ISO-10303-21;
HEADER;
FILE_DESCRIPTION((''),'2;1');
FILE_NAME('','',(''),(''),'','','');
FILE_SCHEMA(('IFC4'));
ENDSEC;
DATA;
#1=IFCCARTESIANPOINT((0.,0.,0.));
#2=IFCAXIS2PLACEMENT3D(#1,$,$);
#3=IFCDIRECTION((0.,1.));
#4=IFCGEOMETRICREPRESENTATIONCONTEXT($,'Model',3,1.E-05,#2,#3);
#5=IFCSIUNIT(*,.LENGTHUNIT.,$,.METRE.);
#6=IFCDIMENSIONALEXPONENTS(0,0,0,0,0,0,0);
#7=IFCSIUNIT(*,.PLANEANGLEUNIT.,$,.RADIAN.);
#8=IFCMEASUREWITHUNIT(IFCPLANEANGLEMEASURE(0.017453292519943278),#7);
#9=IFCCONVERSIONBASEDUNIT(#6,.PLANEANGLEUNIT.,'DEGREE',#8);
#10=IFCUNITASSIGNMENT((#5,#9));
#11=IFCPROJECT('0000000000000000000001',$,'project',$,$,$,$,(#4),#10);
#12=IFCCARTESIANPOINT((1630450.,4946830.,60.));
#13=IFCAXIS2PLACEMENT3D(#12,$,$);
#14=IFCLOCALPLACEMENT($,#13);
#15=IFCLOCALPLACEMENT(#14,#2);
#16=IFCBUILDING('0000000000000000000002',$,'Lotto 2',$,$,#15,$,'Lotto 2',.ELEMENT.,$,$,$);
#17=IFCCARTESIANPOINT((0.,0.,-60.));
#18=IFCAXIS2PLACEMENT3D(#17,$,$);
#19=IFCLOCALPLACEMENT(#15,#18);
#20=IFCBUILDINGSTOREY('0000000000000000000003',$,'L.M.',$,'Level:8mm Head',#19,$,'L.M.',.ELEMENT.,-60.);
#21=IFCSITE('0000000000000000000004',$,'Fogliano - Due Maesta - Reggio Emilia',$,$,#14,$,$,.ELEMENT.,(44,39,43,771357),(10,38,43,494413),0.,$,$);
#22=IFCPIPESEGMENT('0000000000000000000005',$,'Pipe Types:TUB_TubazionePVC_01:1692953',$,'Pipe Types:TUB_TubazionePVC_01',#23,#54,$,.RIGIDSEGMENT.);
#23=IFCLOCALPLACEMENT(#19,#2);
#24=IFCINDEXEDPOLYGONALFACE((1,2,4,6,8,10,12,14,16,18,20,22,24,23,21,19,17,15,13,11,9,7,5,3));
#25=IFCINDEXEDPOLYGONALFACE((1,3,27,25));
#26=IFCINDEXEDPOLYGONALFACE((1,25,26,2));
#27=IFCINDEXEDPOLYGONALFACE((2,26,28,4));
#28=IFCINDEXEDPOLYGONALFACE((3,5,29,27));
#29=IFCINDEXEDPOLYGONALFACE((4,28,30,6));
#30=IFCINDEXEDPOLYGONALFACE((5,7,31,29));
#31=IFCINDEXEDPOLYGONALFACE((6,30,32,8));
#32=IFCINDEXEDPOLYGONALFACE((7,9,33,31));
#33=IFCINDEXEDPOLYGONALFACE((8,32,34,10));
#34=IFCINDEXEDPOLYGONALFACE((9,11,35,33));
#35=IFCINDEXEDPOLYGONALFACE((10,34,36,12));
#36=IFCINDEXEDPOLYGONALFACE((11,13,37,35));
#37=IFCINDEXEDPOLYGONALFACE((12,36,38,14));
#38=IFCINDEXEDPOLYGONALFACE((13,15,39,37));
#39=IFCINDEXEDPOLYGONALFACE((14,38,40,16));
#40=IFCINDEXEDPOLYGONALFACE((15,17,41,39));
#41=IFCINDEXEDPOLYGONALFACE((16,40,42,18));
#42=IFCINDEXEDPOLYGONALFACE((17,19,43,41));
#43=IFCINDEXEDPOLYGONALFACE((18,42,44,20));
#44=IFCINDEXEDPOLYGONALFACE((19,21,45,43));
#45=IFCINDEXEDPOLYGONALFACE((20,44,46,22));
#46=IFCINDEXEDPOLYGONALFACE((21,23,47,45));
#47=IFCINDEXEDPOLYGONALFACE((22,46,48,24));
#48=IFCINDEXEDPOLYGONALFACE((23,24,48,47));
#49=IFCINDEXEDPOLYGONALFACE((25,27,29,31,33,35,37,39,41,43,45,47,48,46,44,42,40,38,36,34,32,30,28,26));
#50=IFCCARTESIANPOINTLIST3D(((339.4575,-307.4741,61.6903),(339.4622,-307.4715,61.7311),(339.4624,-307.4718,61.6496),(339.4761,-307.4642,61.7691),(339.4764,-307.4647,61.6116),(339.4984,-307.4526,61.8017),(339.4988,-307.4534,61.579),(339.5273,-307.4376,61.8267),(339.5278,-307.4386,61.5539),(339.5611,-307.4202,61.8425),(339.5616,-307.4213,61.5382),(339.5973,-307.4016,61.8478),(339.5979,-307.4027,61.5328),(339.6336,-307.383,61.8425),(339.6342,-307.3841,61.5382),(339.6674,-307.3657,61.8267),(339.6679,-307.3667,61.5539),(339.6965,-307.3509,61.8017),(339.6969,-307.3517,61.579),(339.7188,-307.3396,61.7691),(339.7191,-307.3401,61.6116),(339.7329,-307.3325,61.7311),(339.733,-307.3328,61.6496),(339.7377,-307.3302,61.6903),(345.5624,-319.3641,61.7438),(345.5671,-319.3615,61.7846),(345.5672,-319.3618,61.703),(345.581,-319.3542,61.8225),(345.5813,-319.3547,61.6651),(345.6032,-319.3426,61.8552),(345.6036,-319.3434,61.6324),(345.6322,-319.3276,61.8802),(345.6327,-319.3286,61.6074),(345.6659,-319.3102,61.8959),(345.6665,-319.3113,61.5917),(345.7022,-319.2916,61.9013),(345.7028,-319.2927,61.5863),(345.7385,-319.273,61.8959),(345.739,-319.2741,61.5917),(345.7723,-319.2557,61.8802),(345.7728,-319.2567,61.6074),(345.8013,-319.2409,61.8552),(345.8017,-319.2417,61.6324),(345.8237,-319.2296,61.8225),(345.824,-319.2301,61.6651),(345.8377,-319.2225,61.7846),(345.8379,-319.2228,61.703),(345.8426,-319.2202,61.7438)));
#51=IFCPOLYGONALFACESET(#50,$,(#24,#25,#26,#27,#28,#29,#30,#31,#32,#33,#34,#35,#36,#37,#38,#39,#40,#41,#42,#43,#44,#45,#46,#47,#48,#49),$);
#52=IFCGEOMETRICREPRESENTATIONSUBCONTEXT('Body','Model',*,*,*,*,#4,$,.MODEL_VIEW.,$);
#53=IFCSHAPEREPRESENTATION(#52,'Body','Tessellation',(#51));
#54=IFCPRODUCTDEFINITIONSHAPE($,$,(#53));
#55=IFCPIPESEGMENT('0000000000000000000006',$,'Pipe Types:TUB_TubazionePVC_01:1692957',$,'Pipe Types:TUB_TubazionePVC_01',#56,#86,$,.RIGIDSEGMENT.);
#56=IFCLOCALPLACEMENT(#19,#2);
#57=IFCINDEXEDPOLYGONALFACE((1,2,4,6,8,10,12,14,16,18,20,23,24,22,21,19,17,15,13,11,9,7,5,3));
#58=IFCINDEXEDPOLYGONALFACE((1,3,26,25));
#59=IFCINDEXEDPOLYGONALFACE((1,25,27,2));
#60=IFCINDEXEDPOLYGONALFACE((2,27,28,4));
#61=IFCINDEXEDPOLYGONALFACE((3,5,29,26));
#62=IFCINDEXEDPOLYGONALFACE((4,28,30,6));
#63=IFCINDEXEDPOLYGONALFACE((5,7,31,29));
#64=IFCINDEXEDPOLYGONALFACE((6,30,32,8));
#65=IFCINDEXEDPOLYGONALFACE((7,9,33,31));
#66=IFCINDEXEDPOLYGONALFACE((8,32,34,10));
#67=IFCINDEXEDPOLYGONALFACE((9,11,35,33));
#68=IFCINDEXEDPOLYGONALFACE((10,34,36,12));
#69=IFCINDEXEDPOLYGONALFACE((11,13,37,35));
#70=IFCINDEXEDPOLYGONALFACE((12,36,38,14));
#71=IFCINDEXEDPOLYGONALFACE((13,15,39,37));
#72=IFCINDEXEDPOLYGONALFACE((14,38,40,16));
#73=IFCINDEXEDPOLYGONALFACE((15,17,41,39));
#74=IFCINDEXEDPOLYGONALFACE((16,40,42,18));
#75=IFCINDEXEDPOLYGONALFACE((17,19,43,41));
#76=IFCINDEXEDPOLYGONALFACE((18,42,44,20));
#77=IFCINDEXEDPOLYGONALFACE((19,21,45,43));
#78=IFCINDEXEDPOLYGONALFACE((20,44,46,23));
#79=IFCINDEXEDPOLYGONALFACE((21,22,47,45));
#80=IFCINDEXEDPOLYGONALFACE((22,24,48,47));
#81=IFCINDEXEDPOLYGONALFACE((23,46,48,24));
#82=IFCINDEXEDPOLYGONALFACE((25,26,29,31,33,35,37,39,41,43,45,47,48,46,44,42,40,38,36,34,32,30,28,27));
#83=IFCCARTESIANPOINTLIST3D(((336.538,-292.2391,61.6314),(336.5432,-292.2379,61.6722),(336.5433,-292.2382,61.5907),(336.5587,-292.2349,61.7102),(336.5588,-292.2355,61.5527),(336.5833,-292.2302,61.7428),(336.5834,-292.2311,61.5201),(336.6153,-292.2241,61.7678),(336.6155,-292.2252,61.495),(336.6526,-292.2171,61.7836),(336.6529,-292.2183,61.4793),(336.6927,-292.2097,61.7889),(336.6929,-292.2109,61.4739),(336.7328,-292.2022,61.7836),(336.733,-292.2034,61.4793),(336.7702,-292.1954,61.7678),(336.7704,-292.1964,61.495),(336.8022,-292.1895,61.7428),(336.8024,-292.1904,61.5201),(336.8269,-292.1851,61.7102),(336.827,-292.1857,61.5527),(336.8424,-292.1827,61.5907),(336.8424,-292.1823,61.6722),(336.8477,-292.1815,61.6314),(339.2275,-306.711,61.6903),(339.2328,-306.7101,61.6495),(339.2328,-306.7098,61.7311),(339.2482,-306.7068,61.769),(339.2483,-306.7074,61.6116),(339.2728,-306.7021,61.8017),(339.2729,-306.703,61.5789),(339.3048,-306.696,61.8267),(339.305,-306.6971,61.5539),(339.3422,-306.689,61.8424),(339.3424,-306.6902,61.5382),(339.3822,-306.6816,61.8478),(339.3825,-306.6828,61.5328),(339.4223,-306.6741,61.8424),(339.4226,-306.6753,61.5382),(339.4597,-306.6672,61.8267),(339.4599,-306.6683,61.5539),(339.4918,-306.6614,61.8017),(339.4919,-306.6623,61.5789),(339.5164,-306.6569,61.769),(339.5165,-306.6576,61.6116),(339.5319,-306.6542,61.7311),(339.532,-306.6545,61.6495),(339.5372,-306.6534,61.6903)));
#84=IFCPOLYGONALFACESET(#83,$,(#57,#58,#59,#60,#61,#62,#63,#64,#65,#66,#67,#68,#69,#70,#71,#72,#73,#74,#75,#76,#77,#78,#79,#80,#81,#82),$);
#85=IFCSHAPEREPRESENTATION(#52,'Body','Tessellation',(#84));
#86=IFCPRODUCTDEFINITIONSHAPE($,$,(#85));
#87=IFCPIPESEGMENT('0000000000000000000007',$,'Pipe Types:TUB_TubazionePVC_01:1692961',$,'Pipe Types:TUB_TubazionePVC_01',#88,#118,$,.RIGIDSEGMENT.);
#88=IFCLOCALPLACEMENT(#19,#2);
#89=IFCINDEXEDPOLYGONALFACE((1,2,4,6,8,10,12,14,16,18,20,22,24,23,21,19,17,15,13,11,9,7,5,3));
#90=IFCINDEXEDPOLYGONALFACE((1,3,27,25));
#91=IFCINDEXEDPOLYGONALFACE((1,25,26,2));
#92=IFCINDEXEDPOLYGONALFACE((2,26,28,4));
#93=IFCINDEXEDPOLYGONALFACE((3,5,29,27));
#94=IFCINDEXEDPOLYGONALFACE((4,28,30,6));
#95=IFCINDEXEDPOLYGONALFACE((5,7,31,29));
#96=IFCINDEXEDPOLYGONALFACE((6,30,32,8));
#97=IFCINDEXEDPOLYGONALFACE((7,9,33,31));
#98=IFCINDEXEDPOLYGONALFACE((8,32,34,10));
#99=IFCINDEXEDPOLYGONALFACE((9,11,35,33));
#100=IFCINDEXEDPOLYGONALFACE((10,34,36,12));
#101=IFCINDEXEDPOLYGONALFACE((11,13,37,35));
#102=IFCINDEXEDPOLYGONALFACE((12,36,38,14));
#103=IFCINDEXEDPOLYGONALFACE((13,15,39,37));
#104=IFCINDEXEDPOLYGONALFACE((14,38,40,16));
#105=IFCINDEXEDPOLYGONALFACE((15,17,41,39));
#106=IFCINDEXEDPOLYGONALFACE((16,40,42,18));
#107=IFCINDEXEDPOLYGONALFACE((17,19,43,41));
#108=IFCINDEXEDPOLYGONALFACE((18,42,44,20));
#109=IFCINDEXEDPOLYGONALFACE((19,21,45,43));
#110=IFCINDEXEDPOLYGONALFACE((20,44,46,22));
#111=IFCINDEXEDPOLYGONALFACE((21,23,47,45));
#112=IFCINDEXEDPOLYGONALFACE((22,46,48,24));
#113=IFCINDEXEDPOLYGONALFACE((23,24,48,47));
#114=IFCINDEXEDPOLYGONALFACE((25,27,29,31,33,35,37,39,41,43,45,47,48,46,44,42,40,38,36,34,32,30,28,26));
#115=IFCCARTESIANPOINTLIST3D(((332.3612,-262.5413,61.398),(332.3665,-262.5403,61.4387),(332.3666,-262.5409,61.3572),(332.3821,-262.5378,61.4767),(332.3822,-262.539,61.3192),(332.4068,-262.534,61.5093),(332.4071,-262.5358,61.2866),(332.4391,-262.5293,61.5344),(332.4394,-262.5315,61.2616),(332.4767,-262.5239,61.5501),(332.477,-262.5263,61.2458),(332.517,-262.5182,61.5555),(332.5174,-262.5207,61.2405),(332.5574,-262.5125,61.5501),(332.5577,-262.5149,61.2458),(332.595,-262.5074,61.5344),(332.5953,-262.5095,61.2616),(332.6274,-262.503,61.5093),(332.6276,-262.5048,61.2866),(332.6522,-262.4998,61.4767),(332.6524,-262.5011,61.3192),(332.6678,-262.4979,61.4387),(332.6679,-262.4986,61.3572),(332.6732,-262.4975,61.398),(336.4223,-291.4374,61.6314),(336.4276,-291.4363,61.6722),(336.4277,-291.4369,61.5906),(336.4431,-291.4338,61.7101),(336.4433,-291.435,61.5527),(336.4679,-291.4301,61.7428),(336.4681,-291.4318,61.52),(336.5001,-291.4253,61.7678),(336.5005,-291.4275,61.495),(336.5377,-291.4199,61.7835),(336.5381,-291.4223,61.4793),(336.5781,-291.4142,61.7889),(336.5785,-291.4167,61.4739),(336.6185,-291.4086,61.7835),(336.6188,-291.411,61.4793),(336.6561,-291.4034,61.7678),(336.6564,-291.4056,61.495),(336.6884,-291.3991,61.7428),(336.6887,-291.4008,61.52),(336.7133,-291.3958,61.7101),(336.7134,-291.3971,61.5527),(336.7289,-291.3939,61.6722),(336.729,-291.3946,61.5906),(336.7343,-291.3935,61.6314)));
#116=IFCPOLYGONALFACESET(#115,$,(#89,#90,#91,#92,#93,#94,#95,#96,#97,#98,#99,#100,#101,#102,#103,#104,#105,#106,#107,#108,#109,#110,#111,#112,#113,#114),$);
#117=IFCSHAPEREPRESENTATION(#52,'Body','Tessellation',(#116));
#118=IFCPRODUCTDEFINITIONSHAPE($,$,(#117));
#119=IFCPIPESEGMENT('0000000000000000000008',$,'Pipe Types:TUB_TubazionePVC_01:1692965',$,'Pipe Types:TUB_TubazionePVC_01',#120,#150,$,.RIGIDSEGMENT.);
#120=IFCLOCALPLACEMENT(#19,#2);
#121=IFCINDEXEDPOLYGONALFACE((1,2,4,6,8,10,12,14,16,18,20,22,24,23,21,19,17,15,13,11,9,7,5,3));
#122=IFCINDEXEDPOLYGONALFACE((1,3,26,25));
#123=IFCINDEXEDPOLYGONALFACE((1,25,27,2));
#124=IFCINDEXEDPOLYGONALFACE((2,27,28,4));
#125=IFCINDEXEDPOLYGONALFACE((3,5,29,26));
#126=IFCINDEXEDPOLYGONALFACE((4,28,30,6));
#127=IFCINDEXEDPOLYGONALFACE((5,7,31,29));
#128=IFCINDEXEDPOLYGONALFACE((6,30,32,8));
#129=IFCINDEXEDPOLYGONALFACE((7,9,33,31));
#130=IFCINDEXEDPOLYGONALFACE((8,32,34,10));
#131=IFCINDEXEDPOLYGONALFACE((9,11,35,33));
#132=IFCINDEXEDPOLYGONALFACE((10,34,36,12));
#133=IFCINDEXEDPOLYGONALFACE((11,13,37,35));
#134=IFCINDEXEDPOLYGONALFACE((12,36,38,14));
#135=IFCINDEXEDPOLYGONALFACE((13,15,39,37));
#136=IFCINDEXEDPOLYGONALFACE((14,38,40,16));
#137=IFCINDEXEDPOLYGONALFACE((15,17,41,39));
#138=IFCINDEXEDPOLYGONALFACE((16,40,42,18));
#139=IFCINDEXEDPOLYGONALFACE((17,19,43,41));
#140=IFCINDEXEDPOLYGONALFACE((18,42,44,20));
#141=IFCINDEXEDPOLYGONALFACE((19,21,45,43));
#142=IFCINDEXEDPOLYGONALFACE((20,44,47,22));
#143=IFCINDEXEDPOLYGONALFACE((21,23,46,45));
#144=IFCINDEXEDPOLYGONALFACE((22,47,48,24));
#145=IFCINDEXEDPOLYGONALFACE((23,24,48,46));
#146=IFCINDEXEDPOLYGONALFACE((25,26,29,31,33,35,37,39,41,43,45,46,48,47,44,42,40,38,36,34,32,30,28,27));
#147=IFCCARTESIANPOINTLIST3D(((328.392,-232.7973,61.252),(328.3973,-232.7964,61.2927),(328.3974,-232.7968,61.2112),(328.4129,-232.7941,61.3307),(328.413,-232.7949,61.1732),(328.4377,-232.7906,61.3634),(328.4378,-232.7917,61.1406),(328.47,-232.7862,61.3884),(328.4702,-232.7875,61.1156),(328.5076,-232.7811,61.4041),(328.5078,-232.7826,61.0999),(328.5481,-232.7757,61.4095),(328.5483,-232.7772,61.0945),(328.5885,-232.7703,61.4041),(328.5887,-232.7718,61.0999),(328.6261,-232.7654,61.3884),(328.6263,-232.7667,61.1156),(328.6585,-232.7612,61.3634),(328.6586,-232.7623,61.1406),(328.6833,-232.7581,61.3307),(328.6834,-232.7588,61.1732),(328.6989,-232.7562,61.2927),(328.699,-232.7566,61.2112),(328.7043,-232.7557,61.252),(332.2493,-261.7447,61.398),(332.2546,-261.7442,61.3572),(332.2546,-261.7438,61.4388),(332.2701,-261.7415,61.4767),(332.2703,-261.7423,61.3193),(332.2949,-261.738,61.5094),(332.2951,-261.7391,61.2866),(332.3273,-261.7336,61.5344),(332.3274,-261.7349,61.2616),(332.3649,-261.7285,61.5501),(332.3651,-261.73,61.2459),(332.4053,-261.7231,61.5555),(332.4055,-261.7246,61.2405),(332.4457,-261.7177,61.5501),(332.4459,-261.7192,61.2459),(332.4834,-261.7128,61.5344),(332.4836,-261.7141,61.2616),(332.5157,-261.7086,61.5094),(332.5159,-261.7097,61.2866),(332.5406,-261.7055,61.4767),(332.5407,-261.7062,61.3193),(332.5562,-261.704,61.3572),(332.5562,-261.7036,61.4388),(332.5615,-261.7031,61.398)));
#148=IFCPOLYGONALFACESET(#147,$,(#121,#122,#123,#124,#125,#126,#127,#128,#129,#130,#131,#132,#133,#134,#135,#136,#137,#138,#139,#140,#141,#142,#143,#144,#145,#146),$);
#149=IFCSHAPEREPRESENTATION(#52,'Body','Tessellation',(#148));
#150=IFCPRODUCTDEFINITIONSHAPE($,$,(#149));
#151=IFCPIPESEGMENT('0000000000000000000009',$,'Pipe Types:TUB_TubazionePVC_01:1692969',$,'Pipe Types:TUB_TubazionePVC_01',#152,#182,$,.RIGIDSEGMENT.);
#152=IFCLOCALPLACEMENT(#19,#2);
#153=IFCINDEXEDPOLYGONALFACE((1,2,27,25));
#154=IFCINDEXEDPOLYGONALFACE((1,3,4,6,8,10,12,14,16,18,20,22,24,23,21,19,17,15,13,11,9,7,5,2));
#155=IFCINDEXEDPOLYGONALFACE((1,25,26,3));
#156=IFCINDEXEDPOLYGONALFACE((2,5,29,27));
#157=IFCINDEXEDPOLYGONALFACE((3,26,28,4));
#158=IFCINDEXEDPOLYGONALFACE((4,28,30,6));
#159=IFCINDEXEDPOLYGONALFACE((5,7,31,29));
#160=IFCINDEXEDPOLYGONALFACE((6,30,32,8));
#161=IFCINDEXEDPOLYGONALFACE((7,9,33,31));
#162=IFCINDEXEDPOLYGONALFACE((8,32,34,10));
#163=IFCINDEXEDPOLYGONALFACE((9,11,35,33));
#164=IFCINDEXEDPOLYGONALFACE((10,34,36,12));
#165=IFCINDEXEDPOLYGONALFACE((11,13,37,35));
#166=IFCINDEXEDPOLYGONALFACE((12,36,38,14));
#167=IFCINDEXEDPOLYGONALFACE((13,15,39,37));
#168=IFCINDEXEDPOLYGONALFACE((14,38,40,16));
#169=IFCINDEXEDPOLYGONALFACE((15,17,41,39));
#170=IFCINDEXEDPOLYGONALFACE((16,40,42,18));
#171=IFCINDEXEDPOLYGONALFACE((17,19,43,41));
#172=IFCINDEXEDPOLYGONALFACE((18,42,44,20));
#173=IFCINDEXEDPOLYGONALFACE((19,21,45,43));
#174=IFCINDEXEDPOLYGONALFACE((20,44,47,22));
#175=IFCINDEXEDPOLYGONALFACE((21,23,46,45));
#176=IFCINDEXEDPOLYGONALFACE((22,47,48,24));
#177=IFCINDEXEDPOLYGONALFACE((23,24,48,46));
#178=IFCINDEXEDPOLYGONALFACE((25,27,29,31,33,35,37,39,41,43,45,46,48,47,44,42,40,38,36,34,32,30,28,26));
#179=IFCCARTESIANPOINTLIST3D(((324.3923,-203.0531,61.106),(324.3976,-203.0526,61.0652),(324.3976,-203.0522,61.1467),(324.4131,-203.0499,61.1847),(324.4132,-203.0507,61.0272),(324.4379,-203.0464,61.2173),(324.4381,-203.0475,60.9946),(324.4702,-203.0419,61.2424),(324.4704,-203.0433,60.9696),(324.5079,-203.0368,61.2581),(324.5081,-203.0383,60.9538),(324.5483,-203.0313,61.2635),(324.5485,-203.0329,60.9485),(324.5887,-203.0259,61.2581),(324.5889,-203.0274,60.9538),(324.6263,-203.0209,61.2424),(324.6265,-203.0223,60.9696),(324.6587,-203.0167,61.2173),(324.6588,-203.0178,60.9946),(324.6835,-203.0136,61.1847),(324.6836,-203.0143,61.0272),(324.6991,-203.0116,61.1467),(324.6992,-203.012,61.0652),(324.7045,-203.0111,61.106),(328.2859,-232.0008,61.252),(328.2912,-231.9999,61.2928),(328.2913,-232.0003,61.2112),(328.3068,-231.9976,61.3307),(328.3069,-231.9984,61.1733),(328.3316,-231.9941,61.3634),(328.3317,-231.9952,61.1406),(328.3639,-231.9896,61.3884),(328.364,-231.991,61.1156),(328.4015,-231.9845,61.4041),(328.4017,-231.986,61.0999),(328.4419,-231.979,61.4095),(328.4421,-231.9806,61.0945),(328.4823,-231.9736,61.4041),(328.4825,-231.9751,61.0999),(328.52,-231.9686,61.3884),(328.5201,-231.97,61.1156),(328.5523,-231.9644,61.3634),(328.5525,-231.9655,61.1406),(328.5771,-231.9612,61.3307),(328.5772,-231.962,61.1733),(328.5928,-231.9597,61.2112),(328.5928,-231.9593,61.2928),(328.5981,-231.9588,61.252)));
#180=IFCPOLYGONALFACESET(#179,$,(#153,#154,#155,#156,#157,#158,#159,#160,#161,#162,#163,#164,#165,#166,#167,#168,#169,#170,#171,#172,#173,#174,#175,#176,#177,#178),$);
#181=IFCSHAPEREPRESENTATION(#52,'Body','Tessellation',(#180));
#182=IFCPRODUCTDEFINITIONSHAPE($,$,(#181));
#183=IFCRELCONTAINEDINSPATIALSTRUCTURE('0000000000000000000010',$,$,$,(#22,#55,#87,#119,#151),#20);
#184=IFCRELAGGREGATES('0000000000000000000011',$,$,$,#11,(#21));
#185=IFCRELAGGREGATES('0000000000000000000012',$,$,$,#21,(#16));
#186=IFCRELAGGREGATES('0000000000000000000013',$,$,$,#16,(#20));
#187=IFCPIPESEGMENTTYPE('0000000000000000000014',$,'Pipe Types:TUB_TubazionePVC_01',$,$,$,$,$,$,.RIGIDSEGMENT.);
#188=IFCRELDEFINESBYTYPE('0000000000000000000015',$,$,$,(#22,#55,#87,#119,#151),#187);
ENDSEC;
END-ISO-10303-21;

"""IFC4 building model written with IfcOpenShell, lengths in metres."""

from ifc_helpers import new_model, entity, si_unit, converted_unit, direction, frame, origin, place, context, subcontext, project, spatial, arc, indexed_curve, outline, extrude, type_object, element, save


model = new_model("IFC4")

# Units and contexts
model_context = context("Model", 3, precision=1e-05, world=origin(), true_north=direction((0.0, 1.0)))
body_context = subcontext(model_context, "Body", "Model", "MODEL_VIEW")
ifc_project = project(units=[si_unit("LENGTHUNIT", "METRE"), converted_unit("PLANEANGLEUNIT", "DEGREE", entity("IfcPlaneAngleMeasure", 0.017453292519943278), si_unit("PLANEANGLEUNIT", "RADIAN"), dimensions=[0, 0, 0, 0, 0, 0, 0])], contexts=[model_context])

# Site, building, storey
site_placement = place(None, frame((1630450.0, 4946830.0, 60.0)))
site = spatial("IfcSite", under=ifc_project, at=site_placement, Name="Fogliano - Due Maesta - Reggio Emilia", CompositionType="ELEMENT", RefLatitude=(44, 39, 43, 771357), RefLongitude=(10, 38, 43, 494413), RefElevation=0.0)
building_placement = place(site_placement, origin())
building = spatial("IfcBuilding", under=site, at=building_placement, Name="Lotto 2", LongName="Lotto 2", CompositionType="ELEMENT")
storey_placement = place(building_placement, frame((0.0, 0.0, -60.0)))
storey = spatial("IfcBuildingStorey", under=building, at=storey_placement, Name="L.M.", ObjectType="Level:8mm Head", LongName="L.M.", CompositionType="ELEMENT", Elevation=-60.0)

# Pipe segments
pipe_segment_type = type_object("IfcPipeSegmentType", Name="Pipe Types:TUB_TubazionePVC_01", PredefinedType="RIGIDSEGMENT")
pipe_segment_1_placement = place(storey_placement, origin())
element("IfcPipeSegment", 1, at=pipe_segment_1_placement, inside=storey, type_object=pipe_segment_type, Name="Pipe Types:TUB_TubazionePVC_01:1692953", ObjectType="Pipe Types:TUB_TubazionePVC_01", PredefinedType="RIGIDSEGMENT", context=body_context, shape_type="SweptSolid", body=[
    extrude(outline(indexed_curve([(0.1575, 0.0), (0.1114, 0.1114), (0.0, 0.1575), (-0.1114, 0.1114), (-0.1575, 0.0), (-0.1114, -0.1114), (0.0, -0.1575), (0.1114, -0.1114)], segments=[arc(1, 2, 3), arc(3, 4, 5), arc(5, 6, 7), arc(7, 8, 1)], self_intersect=False)), frame((339.5976, -307.4022, 61.6903), z_axis=(0.456751, -0.889585, 0.004), x_axis=(0.889592, 0.456755, 0.0)), (0.0, 0.0, 1.0), 13.3658),
])
pipe_segment_2_placement = place(storey_placement, origin())
element("IfcPipeSegment", 2, at=pipe_segment_2_placement, inside=storey, type_object=pipe_segment_type, Name="Pipe Types:TUB_TubazionePVC_01:1692957", ObjectType="Pipe Types:TUB_TubazionePVC_01", PredefinedType="RIGIDSEGMENT", context=body_context, shape_type="SweptSolid", body=[
    extrude(outline(indexed_curve([(0.1575, 0.0), (0.1114, 0.1114), (0.0, 0.1575), (-0.1114, 0.1114), (-0.1575, 0.0), (-0.1114, -0.1114), (0.0, -0.1575), (0.1114, -0.1114)], segments=[arc(1, 2, 3), arc(3, 4, 5), arc(5, 6, 7), arc(7, 8, 1)], self_intersect=False)), frame((339.3824, -306.6822, 61.6903), z_axis=(-0.182716, 0.983158, -0.004), x_axis=(0.983166, 0.182717, 0.0)), (0.0, 0.0, 1.0), 14.7198),
])
pipe_segment_3_placement = place(storey_placement, origin())
element("IfcPipeSegment", 3, at=pipe_segment_3_placement, inside=storey, type_object=pipe_segment_type, Name="Pipe Types:TUB_TubazionePVC_01:1692961", ObjectType="Pipe Types:TUB_TubazionePVC_01", PredefinedType="RIGIDSEGMENT", context=body_context, shape_type="SweptSolid", body=[
    extrude(outline(indexed_curve([(0.1575, 0.0), (0.1114, 0.1114), (0.0, 0.1575), (-0.1114, 0.1114), (-0.1575, 0.0), (-0.1114, -0.1114), (0.0, -0.1575), (0.1114, -0.1114)], segments=[arc(1, 2, 3), arc(3, 4, 5), arc(5, 6, 7), arc(7, 8, 1)], self_intersect=False)), frame((336.5783, -291.4154, 61.6314), z_axis=(-0.139169, 0.990236, -0.008), x_axis=(0.990268, 0.139173, 0.0)), (0.0, 0.0, 1.0), 29.1809),
])
pipe_segment_4_placement = place(storey_placement, origin())
element("IfcPipeSegment", 4, at=pipe_segment_4_placement, inside=storey, type_object=pipe_segment_type, Name="Pipe Types:TUB_TubazionePVC_01:1692965", ObjectType="Pipe Types:TUB_TubazionePVC_01", PredefinedType="RIGIDSEGMENT", context=body_context, shape_type="SweptSolid", body=[
    extrude(outline(indexed_curve([(0.1575, 0.0), (0.1114, 0.1114), (0.0, 0.1575), (-0.1114, 0.1114), (-0.1575, 0.0), (-0.1114, -0.1114), (0.0, -0.1575), (0.1114, -0.1114)], segments=[arc(1, 2, 3), arc(3, 4, 5), arc(5, 6, 7), arc(7, 8, 1)], self_intersect=False)), frame((332.4054, -261.7239, 61.398), z_axis=(-0.132081, 0.991226, -0.005), x_axis=(0.991239, 0.132083, 0.0)), (0.0, 0.0, 1.0), 29.2036),
])
pipe_segment_5_placement = place(storey_placement, origin())
element("IfcPipeSegment", 5, at=pipe_segment_5_placement, inside=storey, type_object=pipe_segment_type, Name="Pipe Types:TUB_TubazionePVC_01:1692969", ObjectType="Pipe Types:TUB_TubazionePVC_01", PredefinedType="RIGIDSEGMENT", context=body_context, shape_type="SweptSolid", body=[
    extrude(outline(indexed_curve([(0.1575, 0.0), (0.1114, 0.1114), (0.0, 0.1575), (-0.1114, 0.1114), (-0.1575, 0.0), (-0.1114, -0.1114), (0.0, -0.1575), (0.1114, -0.1114)], segments=[arc(1, 2, 3), arc(3, 4, 5), arc(5, 6, 7), arc(7, 8, 1)], self_intersect=False)), frame((324.5484, -203.0321, 61.106), z_axis=(0.133304, -0.991063, 0.005), x_axis=(0.991075, 0.133305, 0.0)), (0.0, 0.0, 1.0), 29.2087),
])

save(model, "model.ifc")
